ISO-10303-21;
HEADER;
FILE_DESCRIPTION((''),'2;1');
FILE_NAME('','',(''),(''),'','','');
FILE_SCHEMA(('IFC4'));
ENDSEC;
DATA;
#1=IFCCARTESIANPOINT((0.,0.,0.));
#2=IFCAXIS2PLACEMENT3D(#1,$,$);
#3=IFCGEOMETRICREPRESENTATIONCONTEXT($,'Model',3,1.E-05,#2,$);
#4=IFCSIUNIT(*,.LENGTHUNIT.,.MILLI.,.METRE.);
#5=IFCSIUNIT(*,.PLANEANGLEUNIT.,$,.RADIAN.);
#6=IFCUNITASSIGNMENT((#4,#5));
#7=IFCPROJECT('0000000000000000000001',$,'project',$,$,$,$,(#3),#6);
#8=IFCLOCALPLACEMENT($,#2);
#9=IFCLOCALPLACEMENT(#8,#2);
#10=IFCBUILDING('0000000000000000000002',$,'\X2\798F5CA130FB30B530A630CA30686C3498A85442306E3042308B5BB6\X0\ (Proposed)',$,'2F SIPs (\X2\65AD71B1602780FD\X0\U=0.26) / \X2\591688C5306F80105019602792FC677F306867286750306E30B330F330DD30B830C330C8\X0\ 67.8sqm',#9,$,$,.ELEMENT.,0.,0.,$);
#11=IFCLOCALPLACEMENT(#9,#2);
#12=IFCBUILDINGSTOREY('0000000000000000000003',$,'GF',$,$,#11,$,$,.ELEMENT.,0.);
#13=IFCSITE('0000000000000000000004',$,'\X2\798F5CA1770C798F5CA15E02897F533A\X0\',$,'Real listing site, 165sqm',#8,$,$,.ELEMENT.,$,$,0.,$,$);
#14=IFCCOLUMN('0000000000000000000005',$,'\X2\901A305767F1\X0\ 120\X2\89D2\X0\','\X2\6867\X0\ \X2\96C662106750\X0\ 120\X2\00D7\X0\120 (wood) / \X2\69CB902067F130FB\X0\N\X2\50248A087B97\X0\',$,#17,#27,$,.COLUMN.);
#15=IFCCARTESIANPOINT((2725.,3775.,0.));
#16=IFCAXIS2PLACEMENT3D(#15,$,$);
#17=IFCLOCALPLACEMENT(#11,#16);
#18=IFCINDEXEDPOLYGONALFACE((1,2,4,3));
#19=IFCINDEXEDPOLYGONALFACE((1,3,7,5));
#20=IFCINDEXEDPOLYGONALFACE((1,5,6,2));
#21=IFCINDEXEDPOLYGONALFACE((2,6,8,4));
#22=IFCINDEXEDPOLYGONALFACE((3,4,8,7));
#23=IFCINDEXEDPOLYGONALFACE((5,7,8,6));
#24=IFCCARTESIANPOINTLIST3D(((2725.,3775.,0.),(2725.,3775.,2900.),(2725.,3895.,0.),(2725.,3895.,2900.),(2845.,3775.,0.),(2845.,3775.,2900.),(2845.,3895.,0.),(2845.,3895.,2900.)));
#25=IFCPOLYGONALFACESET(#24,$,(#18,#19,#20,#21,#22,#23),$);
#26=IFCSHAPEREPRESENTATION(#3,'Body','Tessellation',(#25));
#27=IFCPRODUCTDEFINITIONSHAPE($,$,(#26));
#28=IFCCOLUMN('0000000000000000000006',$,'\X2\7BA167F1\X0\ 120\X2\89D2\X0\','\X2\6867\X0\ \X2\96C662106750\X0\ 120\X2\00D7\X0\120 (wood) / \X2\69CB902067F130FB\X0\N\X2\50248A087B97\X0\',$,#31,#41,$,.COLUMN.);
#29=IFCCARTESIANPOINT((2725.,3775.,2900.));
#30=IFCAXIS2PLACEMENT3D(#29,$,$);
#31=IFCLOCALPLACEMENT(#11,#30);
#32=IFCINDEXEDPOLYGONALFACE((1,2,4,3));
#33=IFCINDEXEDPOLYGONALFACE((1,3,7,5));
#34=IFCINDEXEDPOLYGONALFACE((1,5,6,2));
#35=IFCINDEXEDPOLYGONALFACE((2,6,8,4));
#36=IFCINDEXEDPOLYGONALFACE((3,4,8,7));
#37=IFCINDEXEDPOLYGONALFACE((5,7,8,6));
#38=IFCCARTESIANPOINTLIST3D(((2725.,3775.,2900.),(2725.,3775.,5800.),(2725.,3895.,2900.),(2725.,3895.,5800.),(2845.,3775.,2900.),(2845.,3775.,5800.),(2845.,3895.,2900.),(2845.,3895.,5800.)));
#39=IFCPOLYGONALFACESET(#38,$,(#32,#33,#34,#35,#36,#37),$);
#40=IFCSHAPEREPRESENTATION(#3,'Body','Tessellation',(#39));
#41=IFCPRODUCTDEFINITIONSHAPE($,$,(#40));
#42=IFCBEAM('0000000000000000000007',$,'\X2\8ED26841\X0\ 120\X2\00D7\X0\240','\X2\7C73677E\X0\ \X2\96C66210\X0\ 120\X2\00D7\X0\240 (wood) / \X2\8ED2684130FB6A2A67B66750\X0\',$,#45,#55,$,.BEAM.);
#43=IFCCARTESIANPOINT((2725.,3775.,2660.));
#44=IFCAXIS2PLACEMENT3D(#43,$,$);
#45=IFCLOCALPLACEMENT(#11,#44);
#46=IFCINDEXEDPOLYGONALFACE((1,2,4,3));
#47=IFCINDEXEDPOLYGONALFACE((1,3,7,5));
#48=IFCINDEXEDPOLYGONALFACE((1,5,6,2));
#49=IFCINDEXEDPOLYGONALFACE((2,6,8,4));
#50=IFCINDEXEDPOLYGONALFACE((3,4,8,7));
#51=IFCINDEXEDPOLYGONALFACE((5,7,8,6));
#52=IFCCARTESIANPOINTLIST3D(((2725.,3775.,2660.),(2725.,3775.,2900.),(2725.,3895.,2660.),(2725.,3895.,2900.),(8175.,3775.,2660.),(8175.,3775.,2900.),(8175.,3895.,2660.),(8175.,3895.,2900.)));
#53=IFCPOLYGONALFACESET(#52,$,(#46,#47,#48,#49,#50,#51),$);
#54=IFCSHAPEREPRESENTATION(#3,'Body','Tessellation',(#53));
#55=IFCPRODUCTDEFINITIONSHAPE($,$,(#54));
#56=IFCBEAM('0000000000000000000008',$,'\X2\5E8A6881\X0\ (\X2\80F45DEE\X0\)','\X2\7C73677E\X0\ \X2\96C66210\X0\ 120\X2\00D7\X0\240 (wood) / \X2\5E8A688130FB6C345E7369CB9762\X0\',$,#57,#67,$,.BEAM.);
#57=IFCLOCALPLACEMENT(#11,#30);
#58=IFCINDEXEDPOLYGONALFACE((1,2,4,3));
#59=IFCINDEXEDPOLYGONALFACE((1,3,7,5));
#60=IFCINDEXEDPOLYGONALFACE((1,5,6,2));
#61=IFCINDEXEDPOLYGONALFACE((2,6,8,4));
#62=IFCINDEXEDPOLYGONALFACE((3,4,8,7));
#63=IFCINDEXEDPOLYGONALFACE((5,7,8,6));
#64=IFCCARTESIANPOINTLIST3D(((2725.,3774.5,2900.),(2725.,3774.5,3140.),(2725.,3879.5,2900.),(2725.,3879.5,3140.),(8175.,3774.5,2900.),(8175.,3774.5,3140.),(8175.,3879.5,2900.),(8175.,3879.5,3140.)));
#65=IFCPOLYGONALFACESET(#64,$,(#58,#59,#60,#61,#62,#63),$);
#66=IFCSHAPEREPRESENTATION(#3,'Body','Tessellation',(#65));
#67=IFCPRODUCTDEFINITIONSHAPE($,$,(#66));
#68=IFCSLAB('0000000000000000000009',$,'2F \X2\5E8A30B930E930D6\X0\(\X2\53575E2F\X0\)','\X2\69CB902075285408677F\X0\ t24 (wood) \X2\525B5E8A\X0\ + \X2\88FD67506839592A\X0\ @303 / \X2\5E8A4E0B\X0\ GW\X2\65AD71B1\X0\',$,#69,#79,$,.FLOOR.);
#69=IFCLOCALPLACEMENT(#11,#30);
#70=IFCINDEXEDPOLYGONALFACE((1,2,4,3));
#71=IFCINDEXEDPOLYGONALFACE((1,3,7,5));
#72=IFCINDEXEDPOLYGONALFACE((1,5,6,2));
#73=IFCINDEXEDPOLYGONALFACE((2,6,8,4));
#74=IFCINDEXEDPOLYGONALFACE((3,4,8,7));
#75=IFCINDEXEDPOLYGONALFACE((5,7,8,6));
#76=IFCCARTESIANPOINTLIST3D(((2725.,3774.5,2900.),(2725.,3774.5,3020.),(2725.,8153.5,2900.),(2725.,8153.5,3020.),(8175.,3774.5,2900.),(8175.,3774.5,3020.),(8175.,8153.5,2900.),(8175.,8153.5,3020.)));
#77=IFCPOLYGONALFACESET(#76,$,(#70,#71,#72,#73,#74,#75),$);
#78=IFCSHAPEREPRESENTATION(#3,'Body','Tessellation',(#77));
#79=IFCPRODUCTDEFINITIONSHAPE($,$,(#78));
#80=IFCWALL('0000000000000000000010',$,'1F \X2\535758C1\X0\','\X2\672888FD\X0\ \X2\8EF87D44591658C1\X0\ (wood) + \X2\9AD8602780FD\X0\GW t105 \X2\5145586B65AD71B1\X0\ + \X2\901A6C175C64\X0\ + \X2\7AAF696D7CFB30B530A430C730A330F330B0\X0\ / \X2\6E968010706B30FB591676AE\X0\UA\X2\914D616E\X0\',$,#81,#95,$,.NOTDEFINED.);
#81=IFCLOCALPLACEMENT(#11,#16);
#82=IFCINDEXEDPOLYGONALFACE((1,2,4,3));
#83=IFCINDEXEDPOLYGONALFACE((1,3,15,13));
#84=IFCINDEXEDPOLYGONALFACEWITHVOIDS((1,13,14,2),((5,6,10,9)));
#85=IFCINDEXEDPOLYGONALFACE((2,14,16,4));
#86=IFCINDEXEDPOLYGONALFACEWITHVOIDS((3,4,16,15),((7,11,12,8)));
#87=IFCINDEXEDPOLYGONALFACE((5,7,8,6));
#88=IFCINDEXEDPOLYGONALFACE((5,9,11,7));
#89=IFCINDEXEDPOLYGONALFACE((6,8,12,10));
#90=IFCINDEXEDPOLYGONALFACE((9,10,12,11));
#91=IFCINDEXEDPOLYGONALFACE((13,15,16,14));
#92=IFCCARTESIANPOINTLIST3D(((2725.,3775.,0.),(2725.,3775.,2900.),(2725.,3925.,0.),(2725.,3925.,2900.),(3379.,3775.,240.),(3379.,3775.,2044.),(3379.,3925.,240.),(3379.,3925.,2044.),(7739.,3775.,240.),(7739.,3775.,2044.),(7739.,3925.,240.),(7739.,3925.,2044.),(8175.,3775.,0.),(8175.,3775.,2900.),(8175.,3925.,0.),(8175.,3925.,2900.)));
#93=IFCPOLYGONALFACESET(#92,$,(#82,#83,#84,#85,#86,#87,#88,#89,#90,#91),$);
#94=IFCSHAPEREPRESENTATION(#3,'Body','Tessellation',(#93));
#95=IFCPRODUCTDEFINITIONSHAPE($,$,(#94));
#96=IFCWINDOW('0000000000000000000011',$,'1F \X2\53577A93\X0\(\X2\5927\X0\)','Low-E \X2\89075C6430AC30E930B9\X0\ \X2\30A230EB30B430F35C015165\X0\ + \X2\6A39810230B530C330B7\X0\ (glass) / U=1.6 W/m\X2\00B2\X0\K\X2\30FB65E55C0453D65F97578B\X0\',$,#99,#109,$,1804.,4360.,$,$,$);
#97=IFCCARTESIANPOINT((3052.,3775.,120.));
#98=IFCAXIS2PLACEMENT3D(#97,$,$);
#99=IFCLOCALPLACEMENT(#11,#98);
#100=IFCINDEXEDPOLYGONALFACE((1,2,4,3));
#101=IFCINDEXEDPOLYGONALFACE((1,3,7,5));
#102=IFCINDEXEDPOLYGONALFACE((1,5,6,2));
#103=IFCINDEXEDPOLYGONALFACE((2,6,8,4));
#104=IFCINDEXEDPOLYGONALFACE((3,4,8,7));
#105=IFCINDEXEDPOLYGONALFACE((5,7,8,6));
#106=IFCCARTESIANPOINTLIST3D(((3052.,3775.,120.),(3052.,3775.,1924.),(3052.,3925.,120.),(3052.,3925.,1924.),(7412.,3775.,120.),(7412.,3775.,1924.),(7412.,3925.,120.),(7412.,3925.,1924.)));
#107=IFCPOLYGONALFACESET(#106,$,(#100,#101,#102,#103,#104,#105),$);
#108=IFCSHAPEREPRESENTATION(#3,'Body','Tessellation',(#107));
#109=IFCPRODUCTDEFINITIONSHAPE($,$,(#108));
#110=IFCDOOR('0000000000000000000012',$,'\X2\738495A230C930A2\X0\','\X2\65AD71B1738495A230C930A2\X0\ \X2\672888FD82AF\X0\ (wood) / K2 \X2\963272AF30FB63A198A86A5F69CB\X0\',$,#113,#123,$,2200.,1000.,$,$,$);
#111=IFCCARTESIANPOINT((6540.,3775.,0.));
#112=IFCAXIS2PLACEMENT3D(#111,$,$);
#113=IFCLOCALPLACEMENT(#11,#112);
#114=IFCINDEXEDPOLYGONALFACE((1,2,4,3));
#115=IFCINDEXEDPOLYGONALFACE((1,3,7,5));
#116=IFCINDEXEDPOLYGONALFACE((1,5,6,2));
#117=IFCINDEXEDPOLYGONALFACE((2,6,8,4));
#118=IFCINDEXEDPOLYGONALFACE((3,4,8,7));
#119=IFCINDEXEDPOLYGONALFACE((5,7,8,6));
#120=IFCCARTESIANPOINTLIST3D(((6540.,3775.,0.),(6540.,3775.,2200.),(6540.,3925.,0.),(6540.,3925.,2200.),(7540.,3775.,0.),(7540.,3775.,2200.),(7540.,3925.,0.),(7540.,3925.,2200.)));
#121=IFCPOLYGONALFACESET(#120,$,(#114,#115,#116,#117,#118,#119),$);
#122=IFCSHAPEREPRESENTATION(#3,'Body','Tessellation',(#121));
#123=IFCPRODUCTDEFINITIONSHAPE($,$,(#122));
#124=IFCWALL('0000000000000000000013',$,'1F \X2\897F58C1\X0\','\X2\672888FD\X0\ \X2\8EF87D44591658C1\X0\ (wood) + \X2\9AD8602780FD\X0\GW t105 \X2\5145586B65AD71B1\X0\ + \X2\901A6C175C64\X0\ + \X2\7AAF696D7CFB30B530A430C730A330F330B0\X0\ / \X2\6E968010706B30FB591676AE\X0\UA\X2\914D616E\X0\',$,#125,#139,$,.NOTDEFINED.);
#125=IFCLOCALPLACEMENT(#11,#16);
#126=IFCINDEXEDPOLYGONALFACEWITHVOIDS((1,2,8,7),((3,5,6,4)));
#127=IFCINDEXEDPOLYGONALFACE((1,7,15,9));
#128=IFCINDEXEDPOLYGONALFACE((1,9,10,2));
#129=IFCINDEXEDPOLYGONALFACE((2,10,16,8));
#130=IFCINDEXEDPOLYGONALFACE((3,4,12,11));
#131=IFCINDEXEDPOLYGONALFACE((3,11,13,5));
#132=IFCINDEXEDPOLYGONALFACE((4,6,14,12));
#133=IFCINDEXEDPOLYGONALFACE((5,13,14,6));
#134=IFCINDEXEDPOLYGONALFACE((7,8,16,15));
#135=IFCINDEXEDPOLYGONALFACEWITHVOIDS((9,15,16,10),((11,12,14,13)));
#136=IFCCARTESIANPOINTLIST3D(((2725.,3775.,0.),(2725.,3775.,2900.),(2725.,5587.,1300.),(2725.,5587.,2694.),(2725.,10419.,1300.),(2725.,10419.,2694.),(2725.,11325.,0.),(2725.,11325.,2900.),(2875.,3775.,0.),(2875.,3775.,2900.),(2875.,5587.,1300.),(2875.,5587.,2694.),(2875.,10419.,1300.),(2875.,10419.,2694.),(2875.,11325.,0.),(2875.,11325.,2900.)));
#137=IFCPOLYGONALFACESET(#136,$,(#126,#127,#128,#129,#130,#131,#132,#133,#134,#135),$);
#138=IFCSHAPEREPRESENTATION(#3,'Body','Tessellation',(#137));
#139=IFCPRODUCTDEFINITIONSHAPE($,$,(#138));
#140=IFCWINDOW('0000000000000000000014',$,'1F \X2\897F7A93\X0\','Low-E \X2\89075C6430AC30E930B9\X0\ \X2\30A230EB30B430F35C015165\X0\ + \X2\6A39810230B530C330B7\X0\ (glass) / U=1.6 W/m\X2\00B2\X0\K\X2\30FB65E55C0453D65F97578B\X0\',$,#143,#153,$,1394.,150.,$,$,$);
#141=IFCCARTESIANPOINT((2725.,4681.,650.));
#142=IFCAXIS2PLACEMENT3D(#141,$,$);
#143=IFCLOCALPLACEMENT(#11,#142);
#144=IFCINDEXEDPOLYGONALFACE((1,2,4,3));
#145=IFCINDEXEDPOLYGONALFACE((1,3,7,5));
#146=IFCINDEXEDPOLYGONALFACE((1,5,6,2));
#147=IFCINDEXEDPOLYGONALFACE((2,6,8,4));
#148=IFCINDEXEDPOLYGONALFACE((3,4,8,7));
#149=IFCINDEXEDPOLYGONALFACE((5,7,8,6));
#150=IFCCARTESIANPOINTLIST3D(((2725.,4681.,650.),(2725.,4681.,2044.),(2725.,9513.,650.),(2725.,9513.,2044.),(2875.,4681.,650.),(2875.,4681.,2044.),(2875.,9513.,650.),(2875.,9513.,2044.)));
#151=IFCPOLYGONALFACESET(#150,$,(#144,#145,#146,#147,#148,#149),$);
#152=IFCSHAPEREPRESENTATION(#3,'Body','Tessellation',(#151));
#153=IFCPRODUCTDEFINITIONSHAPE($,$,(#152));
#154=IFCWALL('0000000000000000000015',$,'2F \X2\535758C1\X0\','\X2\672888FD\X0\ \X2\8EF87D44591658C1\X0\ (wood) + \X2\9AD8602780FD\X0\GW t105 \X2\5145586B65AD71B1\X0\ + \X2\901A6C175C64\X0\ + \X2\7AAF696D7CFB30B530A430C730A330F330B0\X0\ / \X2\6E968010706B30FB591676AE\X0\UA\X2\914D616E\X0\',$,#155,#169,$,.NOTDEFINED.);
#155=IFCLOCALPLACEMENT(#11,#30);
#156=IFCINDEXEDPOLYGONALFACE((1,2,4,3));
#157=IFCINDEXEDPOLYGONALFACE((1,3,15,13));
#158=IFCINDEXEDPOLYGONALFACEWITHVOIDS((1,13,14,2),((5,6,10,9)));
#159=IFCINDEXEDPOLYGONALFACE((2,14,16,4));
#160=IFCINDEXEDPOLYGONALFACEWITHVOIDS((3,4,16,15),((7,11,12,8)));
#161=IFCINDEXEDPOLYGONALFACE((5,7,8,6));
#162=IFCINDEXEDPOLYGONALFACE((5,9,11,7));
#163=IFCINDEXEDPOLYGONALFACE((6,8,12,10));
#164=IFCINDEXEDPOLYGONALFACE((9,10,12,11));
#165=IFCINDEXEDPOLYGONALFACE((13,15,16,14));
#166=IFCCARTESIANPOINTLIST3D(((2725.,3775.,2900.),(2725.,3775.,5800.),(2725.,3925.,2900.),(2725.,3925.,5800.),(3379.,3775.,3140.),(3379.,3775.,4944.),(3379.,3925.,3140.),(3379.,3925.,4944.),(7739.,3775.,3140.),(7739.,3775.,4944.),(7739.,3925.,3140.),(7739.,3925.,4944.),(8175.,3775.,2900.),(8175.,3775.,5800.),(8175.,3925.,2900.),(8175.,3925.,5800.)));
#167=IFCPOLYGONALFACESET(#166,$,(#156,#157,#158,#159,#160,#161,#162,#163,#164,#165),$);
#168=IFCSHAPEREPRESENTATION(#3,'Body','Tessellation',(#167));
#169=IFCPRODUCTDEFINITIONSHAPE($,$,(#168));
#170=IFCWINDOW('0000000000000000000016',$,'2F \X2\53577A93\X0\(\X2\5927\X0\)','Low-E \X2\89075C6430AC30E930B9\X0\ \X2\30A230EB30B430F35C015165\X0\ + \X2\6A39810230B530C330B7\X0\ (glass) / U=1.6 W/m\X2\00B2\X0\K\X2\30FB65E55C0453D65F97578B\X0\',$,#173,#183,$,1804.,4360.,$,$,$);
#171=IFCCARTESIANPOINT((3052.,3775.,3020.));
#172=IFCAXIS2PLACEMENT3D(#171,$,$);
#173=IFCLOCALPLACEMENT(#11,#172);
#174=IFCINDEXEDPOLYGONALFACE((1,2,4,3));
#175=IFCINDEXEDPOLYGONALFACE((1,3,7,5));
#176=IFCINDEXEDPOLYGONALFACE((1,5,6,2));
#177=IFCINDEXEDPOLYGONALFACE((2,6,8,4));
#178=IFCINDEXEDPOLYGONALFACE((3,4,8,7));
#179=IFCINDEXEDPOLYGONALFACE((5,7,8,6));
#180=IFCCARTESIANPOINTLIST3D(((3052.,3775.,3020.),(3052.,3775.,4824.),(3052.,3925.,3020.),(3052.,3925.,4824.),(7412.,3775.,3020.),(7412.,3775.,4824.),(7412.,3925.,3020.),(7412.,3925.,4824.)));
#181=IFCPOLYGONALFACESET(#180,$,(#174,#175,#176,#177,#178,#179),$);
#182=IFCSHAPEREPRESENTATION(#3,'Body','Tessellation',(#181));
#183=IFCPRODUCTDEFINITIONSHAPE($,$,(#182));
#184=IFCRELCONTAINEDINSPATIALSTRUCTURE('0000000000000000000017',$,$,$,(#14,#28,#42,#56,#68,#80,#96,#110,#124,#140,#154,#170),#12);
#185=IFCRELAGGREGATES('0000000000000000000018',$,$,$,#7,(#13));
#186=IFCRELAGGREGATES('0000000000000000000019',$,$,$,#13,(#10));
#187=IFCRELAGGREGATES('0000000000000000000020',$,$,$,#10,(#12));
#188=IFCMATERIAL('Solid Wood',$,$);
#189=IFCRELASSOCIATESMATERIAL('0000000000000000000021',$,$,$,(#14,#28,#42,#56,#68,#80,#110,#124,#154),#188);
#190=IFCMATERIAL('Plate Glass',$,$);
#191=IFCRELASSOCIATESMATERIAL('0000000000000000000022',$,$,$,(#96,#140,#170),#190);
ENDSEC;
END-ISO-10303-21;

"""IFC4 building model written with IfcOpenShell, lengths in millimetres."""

from ifc_helpers import new_model, si_unit, frame, frame_2d, origin, place, context, project, spatial, rectangle, extrude, material, element, fill, save


model = new_model("IFC4")

# Units and contexts
model_context = context("Model", 3, precision=1e-05, world=origin())
ifc_project = project(units=[si_unit("LENGTHUNIT", "METRE", prefix="MILLI"), si_unit("PLANEANGLEUNIT", "RADIAN")], contexts=[model_context])

# Site, building, storey
site_placement = place(None, origin())
site = spatial("IfcSite", under=ifc_project, at=site_placement, Name="福岡県福岡市西区", ObjectType="Real listing site, 165sqm", CompositionType="ELEMENT", RefElevation=0.0)
building_placement = place(site_placement, origin())
building = spatial("IfcBuilding", under=site, at=building_placement, Name="福岡・サウナと水風呂のある家 (Proposed)", ObjectType="2F SIPs (断熱性能U=0.26) / 外装は耐候性鋼板と木材のコンポジット 67.8sqm", CompositionType="ELEMENT", ElevationOfRefHeight=0.0, ElevationOfTerrain=0.0)
storey_placement = place(building_placement, origin())
storey = spatial("IfcBuildingStorey", under=building, at=storey_placement, Name="GF", CompositionType="ELEMENT", Elevation=0.0)

# Columns
ifc_material_1 = material(Name="Solid Wood")
column_1_placement = place(storey_placement, frame((2725.0, 3775.0, 0.0)))
element("IfcColumn", 1, at=column_1_placement, inside=storey, material=ifc_material_1, Name="通し柱 120角", Description="桧 集成材 120×120 (wood) / 構造柱・N値計算", PredefinedType="COLUMN", context=model_context, shape_type="SweptSolid", body=[
    extrude(rectangle(XDim=120.0, YDim=120.0, at=frame_2d((60.0, 60.0))), frame((2725.0, 3775.0, 0.0)), (0.0, 0.0, 1.0), 2900.0),
])
column_2_placement = place(storey_placement, frame((2725.0, 3775.0, 2900.0)))
element("IfcColumn", 2, at=column_2_placement, inside=storey, material=ifc_material_1, Name="管柱 120角", Description="桧 集成材 120×120 (wood) / 構造柱・N値計算", PredefinedType="COLUMN", context=model_context, shape_type="SweptSolid", body=[
    extrude(rectangle(XDim=120.0, YDim=120.0, at=frame_2d((60.0, 60.0))), frame((2725.0, 3775.0, 2900.0)), (0.0, 0.0, 1.0), 2900.0),
])

# Beams
beam_1_placement = place(storey_placement, frame((2725.0, 3775.0, 2660.0)))
element("IfcBeam", 3, at=beam_1_placement, inside=storey, material=ifc_material_1, Name="軒桁 120×240", Description="米松 集成 120×240 (wood) / 軒桁・横架材", PredefinedType="BEAM", context=model_context, shape_type="SweptSolid", body=[
    extrude(rectangle(XDim=5450.0, YDim=120.0, at=frame_2d((2725.0, 60.0))), frame((2725.0, 3775.0, 2660.0)), (0.0, 0.0, 1.0), 240.0),
])
beam_2_placement = place(storey_placement, frame((2725.0, 3775.0, 2900.0)))
element("IfcBeam", 4, at=beam_2_placement, inside=storey, material=ifc_material_1, Name="床梁 (胴差)", Description="米松 集成 120×240 (wood) / 床梁・水平構面", PredefinedType="BEAM", context=model_context, shape_type="SweptSolid", body=[
    extrude(rectangle(XDim=5450.0, YDim=105.0, at=frame_2d((2725.0, 52.0))), frame((2725.0, 3775.0, 2900.0)), (0.0, 0.0, 1.0), 240.0),
])

# Slab
slab_1_placement = place(storey_placement, frame((2725.0, 3775.0, 2900.0)))
element("IfcSlab", 5, at=slab_1_placement, inside=storey, material=ifc_material_1, Name="2F 床スラブ(南帯)", Description="構造用合板 t24 (wood) 剛床 + 製材根太 @303 / 床下 GW断熱", PredefinedType="FLOOR", context=model_context, shape_type="SweptSolid", body=[
    extrude(rectangle(XDim=5450.0, YDim=4379.0, at=frame_2d((2725.0, 2189.0))), frame((2725.0, 3775.0, 2900.0)), (0.0, 0.0, 1.0), 120.0),
])

# Wall, openings, window, door
wall_1_placement = place(storey_placement, frame((2725.0, 3775.0, 0.0)))
wall_1 = element("IfcWall", 6, at=wall_1_placement, inside=storey, material=ifc_material_1, Name="1F 南壁", Description="木製 軸組外壁 (wood) + 高性能GW t105 充填断熱 + 通気層 + 窯業系サイディング / 準耐火・外皮UA配慮", PredefinedType="NOTDEFINED", context=model_context, shape_type="SweptSolid", body=[
    extrude(rectangle(XDim=5450.0, YDim=150.0, at=frame_2d((2725.0, 75.0))), frame((2725.0, 3775.0, 0.0)), (0.0, 0.0, 1.0), 2900.0),
])
opening_1_placement = place(storey_placement, frame((3052.0, 3775.0, 120.0)))
opening_1 = element("IfcOpeningElement", 7, at=opening_1_placement, cuts=wall_1, PredefinedType="NOTDEFINED", context=model_context, shape_type="SweptSolid", body=[
    extrude(rectangle(XDim=4360.0, YDim=150.0, at=frame_2d((2180.0, 75.0))), frame((3052.0, 3775.0, 120.0)), (0.0, 0.0, 1.0), 1804.0),
])
opening_2_placement = place(storey_placement, frame((6540.0, 3775.0, 0.0)))
opening_2 = element("IfcOpeningElement", 8, at=opening_2_placement, cuts=wall_1, PredefinedType="NOTDEFINED", context=model_context, shape_type="SweptSolid", body=[
    extrude(rectangle(XDim=1000.0, YDim=150.0, at=frame_2d((500.0, 75.0))), frame((6540.0, 3775.0, 0.0)), (0.0, 0.0, 1.0), 2200.0),
])
ifc_material_2 = material(Name="Plate Glass")
window_1_placement = place(storey_placement, frame((3052.0, 3775.0, 120.0)))
window_1 = element("IfcWindow", 9, at=window_1_placement, inside=storey, material=ifc_material_2, Name="1F 南窓(大)", Description="Low-E 複層ガラス アルゴン封入 + 樹脂サッシ (glass) / U=1.6 W/m²K・日射取得型", OverallHeight=1804.0, OverallWidth=4360.0, context=model_context, shape_type="SweptSolid", body=[
    extrude(rectangle(XDim=4360.0, YDim=150.0, at=frame_2d((2180.0, 75.0))), frame((3052.0, 3775.0, 120.0)), (0.0, 0.0, 1.0), 1804.0),
])
fill(opening_1, window_1)
door_placement = place(storey_placement, frame((6540.0, 3775.0, 0.0)))
door = element("IfcDoor", 10, at=door_placement, inside=storey, material=ifc_material_1, Name="玄関ドア", Description="断熱玄関ドア 木製芯 (wood) / K2 防犯・採風機構", OverallHeight=2200.0, OverallWidth=1000.0, context=model_context, shape_type="SweptSolid", body=[
    extrude(rectangle(XDim=1000.0, YDim=150.0, at=frame_2d((500.0, 75.0))), frame((6540.0, 3775.0, 0.0)), (0.0, 0.0, 1.0), 2200.0),
])
fill(opening_2, door)

# Walls, openings, windows
wall_2_placement = place(storey_placement, frame((2725.0, 3775.0, 0.0)))
wall_2 = element("IfcWall", 11, at=wall_2_placement, inside=storey, material=ifc_material_1, Name="1F 西壁", Description="木製 軸組外壁 (wood) + 高性能GW t105 充填断熱 + 通気層 + 窯業系サイディング / 準耐火・外皮UA配慮", PredefinedType="NOTDEFINED", context=model_context, shape_type="SweptSolid", body=[
    extrude(rectangle(XDim=150.0, YDim=7550.0, at=frame_2d((75.0, 3775.0))), frame((2725.0, 3775.0, 0.0)), (0.0, 0.0, 1.0), 2900.0),
])
opening_3_placement = place(storey_placement, frame((2725.0, 4681.0, 650.0)))
opening_3 = element("IfcOpeningElement", 12, at=opening_3_placement, cuts=wall_2, PredefinedType="NOTDEFINED", context=model_context, shape_type="SweptSolid", body=[
    extrude(rectangle(XDim=150.0, YDim=4832.0, at=frame_2d((75.0, 2416.0))), frame((2725.0, 4681.0, 650.0)), (0.0, 0.0, 1.0), 1394.0),
])
window_2_placement = place(storey_placement, frame((2725.0, 4681.0, 650.0)))
window_2 = element("IfcWindow", 13, at=window_2_placement, inside=storey, material=ifc_material_2, Name="1F 西窓", Description="Low-E 複層ガラス アルゴン封入 + 樹脂サッシ (glass) / U=1.6 W/m²K・日射取得型", OverallHeight=1394.0, OverallWidth=150.0, context=model_context, shape_type="SweptSolid", body=[
    extrude(rectangle(XDim=150.0, YDim=4832.0, at=frame_2d((75.0, 2416.0))), frame((2725.0, 4681.0, 650.0)), (0.0, 0.0, 1.0), 1394.0),
])
fill(opening_3, window_2)
wall_3_placement = place(storey_placement, frame((2725.0, 3775.0, 2900.0)))
wall_3 = element("IfcWall", 14, at=wall_3_placement, inside=storey, material=ifc_material_1, Name="2F 南壁", Description="木製 軸組外壁 (wood) + 高性能GW t105 充填断熱 + 通気層 + 窯業系サイディング / 準耐火・外皮UA配慮", PredefinedType="NOTDEFINED", context=model_context, shape_type="SweptSolid", body=[
    extrude(rectangle(XDim=5450.0, YDim=150.0, at=frame_2d((2725.0, 75.0))), frame((2725.0, 3775.0, 2900.0)), (0.0, 0.0, 1.0), 2900.0),
])
opening_4_placement = place(storey_placement, frame((3052.0, 3775.0, 3020.0)))
opening_4 = element("IfcOpeningElement", 15, at=opening_4_placement, cuts=wall_3, PredefinedType="NOTDEFINED", context=model_context, shape_type="SweptSolid", body=[
    extrude(rectangle(XDim=4360.0, YDim=150.0, at=frame_2d((2180.0, 75.0))), frame((3052.0, 3775.0, 3020.0)), (0.0, 0.0, 1.0), 1804.0),
])
window_3_placement = place(storey_placement, frame((3052.0, 3775.0, 3020.0)))
window_3 = element("IfcWindow", 16, at=window_3_placement, inside=storey, material=ifc_material_2, Name="2F 南窓(大)", Description="Low-E 複層ガラス アルゴン封入 + 樹脂サッシ (glass) / U=1.6 W/m²K・日射取得型", OverallHeight=1804.0, OverallWidth=4360.0, context=model_context, shape_type="SweptSolid", body=[
    extrude(rectangle(XDim=4360.0, YDim=150.0, at=frame_2d((2180.0, 75.0))), frame((3052.0, 3775.0, 3020.0)), (0.0, 0.0, 1.0), 1804.0),
])
fill(opening_4, window_3)

save(model, "model.ifc")
